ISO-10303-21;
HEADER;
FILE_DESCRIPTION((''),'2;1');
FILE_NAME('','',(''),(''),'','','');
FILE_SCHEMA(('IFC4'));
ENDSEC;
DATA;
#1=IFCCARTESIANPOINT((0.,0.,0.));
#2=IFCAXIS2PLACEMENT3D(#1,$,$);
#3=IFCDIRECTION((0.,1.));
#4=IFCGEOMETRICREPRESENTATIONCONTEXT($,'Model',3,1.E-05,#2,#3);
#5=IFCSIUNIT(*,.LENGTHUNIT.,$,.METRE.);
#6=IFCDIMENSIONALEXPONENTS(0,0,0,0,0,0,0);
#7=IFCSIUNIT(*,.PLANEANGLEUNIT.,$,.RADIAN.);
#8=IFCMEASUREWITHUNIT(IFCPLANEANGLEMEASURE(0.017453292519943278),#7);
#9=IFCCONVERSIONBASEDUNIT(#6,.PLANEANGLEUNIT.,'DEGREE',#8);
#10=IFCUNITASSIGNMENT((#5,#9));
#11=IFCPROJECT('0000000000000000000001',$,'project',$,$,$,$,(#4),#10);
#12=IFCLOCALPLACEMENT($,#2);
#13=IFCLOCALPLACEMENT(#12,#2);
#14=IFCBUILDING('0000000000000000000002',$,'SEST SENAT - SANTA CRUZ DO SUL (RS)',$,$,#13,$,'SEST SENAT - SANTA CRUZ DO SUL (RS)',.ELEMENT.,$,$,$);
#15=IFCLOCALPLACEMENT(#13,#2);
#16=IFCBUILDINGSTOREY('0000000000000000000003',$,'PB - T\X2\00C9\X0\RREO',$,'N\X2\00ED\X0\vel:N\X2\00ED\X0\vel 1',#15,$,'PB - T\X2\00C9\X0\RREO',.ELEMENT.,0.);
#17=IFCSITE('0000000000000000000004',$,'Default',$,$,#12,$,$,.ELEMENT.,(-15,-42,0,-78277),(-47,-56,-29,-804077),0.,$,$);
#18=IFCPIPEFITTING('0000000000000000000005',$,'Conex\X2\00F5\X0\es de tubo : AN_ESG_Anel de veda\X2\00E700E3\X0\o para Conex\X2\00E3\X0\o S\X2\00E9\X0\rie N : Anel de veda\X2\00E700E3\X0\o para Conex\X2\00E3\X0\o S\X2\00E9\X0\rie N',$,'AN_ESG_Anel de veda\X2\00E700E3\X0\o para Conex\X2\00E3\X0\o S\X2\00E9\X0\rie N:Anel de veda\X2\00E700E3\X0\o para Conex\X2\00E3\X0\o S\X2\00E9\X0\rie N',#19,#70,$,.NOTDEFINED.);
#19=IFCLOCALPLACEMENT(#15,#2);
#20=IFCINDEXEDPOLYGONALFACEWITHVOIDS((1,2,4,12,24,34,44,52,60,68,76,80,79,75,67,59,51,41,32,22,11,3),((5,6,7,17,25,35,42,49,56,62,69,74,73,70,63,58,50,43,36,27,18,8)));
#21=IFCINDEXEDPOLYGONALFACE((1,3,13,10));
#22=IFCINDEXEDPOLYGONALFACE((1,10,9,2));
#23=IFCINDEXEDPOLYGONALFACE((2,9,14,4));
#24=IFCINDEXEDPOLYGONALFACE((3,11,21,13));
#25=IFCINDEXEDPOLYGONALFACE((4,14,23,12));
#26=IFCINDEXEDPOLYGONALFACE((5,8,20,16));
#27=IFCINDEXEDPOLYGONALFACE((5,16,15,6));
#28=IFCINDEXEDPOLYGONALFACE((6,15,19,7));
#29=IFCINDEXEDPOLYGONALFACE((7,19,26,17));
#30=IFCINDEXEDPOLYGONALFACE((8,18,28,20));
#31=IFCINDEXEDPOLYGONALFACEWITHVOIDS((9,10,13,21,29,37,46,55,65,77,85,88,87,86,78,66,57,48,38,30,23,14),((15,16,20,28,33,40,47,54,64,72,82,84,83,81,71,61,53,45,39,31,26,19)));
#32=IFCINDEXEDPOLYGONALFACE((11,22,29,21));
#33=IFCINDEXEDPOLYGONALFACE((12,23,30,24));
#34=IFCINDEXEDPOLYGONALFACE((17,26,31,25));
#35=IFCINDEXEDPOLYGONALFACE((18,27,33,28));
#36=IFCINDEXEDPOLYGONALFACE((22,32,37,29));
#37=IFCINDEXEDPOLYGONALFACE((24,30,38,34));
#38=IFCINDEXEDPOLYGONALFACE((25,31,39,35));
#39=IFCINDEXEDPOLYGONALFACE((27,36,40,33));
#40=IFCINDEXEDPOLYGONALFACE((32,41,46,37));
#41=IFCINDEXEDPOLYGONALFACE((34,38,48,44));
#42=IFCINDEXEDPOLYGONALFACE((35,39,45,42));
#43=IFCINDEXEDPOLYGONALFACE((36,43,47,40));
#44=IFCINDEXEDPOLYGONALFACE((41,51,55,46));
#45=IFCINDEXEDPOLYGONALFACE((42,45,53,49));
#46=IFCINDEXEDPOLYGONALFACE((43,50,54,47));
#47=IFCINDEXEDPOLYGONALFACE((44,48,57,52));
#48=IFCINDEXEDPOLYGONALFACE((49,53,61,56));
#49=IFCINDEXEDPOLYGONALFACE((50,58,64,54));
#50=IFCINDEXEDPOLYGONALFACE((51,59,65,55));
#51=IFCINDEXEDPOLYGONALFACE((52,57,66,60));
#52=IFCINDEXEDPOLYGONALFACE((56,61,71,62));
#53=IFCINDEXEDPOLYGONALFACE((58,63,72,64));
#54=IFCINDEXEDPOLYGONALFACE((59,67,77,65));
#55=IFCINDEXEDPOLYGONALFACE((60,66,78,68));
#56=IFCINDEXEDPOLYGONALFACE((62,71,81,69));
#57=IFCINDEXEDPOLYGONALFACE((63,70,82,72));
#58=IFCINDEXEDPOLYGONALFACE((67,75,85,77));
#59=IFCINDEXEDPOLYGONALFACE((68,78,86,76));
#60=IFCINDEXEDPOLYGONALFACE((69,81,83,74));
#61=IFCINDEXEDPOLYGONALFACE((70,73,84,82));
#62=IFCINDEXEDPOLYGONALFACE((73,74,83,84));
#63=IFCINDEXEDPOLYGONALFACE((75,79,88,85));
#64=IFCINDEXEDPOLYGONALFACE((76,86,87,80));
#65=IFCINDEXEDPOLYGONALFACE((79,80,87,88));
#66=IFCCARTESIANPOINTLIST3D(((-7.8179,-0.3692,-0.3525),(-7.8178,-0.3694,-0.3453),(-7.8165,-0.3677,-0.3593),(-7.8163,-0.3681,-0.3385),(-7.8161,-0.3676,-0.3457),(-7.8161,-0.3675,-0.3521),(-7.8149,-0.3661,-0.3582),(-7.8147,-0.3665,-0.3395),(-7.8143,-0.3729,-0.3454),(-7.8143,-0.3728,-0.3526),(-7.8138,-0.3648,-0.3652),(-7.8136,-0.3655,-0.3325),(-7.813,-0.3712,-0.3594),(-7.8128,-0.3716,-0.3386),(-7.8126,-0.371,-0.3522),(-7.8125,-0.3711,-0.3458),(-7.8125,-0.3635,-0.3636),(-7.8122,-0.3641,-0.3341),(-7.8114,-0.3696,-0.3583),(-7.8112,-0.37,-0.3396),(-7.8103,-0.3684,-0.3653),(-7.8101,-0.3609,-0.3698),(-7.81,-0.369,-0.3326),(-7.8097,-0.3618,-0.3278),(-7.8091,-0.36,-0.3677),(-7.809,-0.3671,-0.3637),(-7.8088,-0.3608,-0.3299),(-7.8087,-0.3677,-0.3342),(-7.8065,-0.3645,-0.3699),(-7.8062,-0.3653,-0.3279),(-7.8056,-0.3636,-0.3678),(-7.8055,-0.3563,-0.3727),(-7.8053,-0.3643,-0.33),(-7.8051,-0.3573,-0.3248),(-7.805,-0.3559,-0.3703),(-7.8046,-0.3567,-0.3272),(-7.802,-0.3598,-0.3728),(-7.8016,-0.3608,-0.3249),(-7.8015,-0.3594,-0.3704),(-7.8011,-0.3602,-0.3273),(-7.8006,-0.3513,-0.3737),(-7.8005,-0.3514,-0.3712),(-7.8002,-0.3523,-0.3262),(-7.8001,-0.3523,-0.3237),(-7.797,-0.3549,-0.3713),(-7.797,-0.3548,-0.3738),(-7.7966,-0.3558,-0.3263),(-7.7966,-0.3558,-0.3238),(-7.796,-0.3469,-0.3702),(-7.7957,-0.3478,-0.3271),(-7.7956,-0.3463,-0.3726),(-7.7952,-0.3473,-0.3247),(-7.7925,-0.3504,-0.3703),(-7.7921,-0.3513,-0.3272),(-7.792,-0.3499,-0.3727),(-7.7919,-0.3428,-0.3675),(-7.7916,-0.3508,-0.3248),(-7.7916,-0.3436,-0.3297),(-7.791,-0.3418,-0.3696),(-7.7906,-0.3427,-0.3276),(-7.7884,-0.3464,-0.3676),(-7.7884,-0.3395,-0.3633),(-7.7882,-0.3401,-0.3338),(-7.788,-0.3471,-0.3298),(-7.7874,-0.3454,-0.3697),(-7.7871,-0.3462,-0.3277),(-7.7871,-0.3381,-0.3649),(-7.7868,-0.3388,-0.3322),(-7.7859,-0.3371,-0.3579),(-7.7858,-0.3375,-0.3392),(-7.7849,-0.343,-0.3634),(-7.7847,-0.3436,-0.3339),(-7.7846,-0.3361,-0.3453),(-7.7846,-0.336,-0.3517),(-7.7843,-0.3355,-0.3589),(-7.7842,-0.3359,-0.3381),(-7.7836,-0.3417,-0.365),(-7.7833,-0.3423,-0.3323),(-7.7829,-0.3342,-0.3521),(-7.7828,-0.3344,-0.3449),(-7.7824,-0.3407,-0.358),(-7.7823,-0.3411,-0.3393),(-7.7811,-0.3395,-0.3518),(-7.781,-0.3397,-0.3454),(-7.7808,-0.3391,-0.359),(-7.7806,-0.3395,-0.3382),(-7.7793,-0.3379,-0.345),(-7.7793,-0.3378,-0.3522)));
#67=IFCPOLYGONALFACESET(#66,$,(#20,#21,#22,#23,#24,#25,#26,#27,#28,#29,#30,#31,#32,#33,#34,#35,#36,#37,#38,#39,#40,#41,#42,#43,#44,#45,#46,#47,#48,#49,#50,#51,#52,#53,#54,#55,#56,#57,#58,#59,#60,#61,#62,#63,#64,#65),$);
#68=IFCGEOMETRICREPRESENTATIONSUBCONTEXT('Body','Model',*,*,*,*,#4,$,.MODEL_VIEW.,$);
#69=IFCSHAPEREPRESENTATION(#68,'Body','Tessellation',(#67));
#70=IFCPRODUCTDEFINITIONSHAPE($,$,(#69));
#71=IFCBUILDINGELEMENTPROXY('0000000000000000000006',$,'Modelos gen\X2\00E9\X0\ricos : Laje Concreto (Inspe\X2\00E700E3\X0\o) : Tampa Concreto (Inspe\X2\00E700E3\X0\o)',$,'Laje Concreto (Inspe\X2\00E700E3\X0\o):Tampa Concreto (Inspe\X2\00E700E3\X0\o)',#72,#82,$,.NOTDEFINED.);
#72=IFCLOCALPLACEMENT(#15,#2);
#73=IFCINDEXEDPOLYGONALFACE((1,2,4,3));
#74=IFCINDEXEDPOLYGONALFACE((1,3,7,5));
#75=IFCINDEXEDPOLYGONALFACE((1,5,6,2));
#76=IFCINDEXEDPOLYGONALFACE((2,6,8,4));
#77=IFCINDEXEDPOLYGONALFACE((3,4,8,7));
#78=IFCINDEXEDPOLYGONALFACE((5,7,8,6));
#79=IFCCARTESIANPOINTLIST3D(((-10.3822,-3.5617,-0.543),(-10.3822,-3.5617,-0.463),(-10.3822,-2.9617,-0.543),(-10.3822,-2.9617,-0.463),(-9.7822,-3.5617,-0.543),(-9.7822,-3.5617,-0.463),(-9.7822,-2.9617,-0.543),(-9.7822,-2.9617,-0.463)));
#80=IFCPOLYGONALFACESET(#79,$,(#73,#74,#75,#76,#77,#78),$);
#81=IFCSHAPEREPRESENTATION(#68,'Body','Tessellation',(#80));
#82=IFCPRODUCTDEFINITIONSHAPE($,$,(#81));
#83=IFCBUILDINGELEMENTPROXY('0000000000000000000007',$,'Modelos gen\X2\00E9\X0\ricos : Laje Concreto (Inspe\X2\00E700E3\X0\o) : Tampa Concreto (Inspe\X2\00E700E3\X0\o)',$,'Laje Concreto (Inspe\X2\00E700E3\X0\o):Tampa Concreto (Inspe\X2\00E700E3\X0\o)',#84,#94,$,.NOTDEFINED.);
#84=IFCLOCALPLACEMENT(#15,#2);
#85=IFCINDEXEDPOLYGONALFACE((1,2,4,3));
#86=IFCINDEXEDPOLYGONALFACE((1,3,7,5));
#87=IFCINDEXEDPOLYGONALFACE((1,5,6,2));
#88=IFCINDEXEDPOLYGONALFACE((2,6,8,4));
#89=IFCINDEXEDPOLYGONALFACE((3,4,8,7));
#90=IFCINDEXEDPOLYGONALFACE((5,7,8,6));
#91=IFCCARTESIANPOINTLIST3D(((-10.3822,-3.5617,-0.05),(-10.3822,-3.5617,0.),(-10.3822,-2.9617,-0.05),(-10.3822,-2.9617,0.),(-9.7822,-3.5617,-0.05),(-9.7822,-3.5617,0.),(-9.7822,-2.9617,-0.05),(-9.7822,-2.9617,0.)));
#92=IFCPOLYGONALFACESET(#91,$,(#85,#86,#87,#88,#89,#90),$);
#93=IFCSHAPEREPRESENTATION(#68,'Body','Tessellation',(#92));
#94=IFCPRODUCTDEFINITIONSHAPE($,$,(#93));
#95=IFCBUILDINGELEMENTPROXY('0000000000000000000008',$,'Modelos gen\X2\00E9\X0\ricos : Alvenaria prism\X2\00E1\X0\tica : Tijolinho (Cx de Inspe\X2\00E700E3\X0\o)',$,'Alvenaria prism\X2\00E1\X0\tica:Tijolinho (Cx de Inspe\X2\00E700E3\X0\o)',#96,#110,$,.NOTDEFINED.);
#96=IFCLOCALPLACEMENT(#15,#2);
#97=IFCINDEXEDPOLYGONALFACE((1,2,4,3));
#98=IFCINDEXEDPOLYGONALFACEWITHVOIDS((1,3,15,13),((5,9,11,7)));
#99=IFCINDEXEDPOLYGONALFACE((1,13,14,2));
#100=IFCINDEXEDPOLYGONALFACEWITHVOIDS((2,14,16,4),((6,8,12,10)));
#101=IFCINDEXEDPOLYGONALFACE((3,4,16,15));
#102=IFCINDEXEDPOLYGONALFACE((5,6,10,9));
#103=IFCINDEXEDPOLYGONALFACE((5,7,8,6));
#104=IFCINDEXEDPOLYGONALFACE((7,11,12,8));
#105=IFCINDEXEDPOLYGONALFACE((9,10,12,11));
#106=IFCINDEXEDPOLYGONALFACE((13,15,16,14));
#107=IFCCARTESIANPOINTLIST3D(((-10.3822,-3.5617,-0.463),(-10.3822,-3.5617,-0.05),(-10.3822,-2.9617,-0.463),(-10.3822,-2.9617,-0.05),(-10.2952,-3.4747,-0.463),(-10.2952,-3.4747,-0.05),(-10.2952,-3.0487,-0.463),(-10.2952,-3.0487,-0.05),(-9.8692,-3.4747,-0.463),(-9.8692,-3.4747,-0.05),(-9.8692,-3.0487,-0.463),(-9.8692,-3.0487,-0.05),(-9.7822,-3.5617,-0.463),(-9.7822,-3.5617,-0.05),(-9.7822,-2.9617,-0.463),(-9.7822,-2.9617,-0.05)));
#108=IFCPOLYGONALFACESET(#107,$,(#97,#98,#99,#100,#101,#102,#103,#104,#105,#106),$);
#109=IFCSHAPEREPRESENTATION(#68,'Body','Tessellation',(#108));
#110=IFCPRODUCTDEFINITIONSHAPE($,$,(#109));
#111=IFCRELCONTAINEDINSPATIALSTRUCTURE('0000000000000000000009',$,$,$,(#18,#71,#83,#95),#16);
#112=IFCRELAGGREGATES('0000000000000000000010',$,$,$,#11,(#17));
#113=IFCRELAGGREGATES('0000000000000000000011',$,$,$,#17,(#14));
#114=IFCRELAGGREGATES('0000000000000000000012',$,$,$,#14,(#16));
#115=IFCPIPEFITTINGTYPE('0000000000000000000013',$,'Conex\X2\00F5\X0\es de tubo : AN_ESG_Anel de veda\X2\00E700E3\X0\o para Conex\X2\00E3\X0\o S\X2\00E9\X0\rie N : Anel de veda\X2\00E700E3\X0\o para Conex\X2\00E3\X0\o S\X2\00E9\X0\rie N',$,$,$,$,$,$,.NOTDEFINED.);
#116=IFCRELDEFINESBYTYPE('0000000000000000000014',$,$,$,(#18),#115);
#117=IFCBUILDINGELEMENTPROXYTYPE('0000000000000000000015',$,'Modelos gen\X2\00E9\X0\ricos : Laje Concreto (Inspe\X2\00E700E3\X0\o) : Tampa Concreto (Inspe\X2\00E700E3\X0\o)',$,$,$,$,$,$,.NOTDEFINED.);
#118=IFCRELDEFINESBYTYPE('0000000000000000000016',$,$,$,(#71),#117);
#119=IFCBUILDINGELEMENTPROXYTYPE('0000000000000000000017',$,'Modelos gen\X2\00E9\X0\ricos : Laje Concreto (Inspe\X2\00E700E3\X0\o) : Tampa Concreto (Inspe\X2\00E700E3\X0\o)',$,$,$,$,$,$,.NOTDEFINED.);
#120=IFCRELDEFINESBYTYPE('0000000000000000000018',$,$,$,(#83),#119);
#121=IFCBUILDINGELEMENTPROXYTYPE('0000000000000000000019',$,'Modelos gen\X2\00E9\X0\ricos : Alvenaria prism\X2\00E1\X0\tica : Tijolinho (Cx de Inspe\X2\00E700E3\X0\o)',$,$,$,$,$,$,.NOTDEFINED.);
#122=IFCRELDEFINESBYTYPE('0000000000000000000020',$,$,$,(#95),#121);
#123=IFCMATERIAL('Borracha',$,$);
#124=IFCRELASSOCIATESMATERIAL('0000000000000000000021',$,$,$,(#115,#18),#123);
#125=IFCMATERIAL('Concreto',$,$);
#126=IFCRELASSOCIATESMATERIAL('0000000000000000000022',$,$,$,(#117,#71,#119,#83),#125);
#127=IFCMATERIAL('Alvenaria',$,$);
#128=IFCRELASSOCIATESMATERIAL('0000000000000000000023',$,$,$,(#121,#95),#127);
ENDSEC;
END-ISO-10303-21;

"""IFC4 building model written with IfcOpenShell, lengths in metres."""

from ifc_helpers import new_model, entity, si_unit, converted_unit, direction, frame, origin, place, context, subcontext, project, spatial, arc, indexed_curve, outline, extrude, source, transform, mapped, material, type_object, type_shapes, element, save


model = new_model("IFC4")

# Units and contexts
model_context = context("Model", 3, precision=1e-05, world=origin(), true_north=direction((0.0, 1.0)))
body_context = subcontext(model_context, "Body", "Model", "MODEL_VIEW")
ifc_project = project(units=[si_unit("LENGTHUNIT", "METRE"), converted_unit("PLANEANGLEUNIT", "DEGREE", entity("IfcPlaneAngleMeasure", 0.017453292519943278), si_unit("PLANEANGLEUNIT", "RADIAN"), dimensions=[0, 0, 0, 0, 0, 0, 0])], contexts=[model_context])

# Site, building, storey
site_placement = place(None, origin())
site = spatial("IfcSite", under=ifc_project, at=site_placement, Name="Default", CompositionType="ELEMENT", RefLatitude=(-15, -42, 0, -78277), RefLongitude=(-47, -56, -29, -804077), RefElevation=0.0)
building_placement = place(site_placement, origin())
building = spatial("IfcBuilding", under=site, at=building_placement, Name="SEST SENAT - SANTA CRUZ DO SUL (RS)", LongName="SEST SENAT - SANTA CRUZ DO SUL (RS)", CompositionType="ELEMENT")
storey_placement = place(building_placement, origin())
storey = spatial("IfcBuildingStorey", under=building, at=storey_placement, Name="PB - TÉRREO", ObjectType="Nível:Nível 1", LongName="PB - TÉRREO", CompositionType="ELEMENT", Elevation=0.0)

# Pipe fitting
ifc_material_1 = material(Name="Borracha")
pipe_fitting_type_1 = type_object("IfcPipeFittingType", Name="Conexões de tubo : AN_ESG_Anel de vedação para Conexão Série N : Anel de vedação para Conexão Série N", PredefinedType="NOTDEFINED", material=ifc_material_1)
shared_shape_1 = source(origin(), body_context, "Body", "SweptSolid", [
    extrude(outline(indexed_curve([(-0.025, 0.0), (0.0, -0.025), (0.025, 0.0), (0.0, 0.025)], segments=[arc(1, 2, 3), arc(3, 4, 1)], self_intersect=False), holes=[indexed_curve([(-0.0225, 0.0), (0.0, 0.0225), (0.0225, 0.0), (0.0, -0.0225)], segments=[arc(1, 2, 3), arc(3, 4, 1)], self_intersect=False)]), frame((0.0, 0.0, -0.005)), (0.0, 0.0, 1.0), 0.005),
])
type_shapes(pipe_fitting_type_1, [shared_shape_1])
for number, where, z_axis, x_axis, name in (
    (1, (-7.8003, -0.3518, -0.3487), (-0.706948, 0.706983, 0.019996), (0.008332, -0.019945, 0.999766), "Conexões de tubo : AN_ESG_Anel de vedação para Conexão Série N : Anel de vedação para Conexão Série N"),
):
    element("IfcPipeFitting", number, at=place(storey_placement, frame(where, z_axis=z_axis, x_axis=x_axis)), inside=storey, type_object=pipe_fitting_type_1, material=ifc_material_1, Name=name, ObjectType="AN_ESG_Anel de vedação para Conexão Série N:Anel de vedação para Conexão Série N", PredefinedType="NOTDEFINED", context=body_context, shape_type="MappedRepresentation", body=[
        mapped(shared_shape_1, transform((0.0, 0.0, 0.0), scale=1.0)),
    ])

# Building element proxies
ifc_material_2 = material(Name="Concreto")
building_element_proxy_type_1 = type_object("IfcBuildingElementProxyType", Name="Modelos genéricos : Laje Concreto (Inspeção) : Tampa Concreto (Inspeção)", PredefinedType="NOTDEFINED", material=ifc_material_2)
shared_shape_2 = source(origin(), body_context, "Body", "SweptSolid", [
    extrude(outline(indexed_curve([(-0.3, -0.3), (0.3, -0.3), (0.3, 0.3), (-0.3, 0.3), (-0.3, -0.3)], self_intersect=False)), frame((0.3, 0.0, -0.08), z_axis=(0.0, 0.0, 1.0), x_axis=(-1.0, 0.0, 0.0)), (0.0, 0.0, 1.0), 0.08),
])
type_shapes(building_element_proxy_type_1, [shared_shape_2])
proxy_1_placement = place(storey_placement, frame((-9.7822, -3.2617, -0.463), z_axis=(0.0, 0.0, 1.0), x_axis=(-1.0, 0.0, 0.0)))
element("IfcBuildingElementProxy", 2, at=proxy_1_placement, inside=storey, type_object=building_element_proxy_type_1, material=ifc_material_2, Name="Modelos genéricos : Laje Concreto (Inspeção) : Tampa Concreto (Inspeção)", ObjectType="Laje Concreto (Inspeção):Tampa Concreto (Inspeção)", PredefinedType="NOTDEFINED", context=body_context, shape_type="MappedRepresentation", body=[
    mapped(shared_shape_2, transform((0.0, 0.0, 0.0), scale=1.0)),
])
building_element_proxy_type_2 = type_object("IfcBuildingElementProxyType", Name="Modelos genéricos : Laje Concreto (Inspeção) : Tampa Concreto (Inspeção)", PredefinedType="NOTDEFINED", material=ifc_material_2)
shared_shape_3 = source(origin(), body_context, "Body", "SweptSolid", [
    extrude(outline(indexed_curve([(-0.3, -0.3), (0.3, -0.3), (0.3, 0.3), (-0.3, 0.3), (-0.3, -0.3)], self_intersect=False)), frame((0.3, 0.0, -0.05), z_axis=(0.0, 0.0, 1.0), x_axis=(-1.0, 0.0, 0.0)), (0.0, 0.0, 1.0), 0.05),
])
type_shapes(building_element_proxy_type_2, [shared_shape_3])
proxy_2_placement = place(storey_placement, frame((-9.7822, -3.2617, 0.0), z_axis=(0.0, 0.0, 1.0), x_axis=(-1.0, 0.0, 0.0)))
element("IfcBuildingElementProxy", 3, at=proxy_2_placement, inside=storey, type_object=building_element_proxy_type_2, material=ifc_material_2, Name="Modelos genéricos : Laje Concreto (Inspeção) : Tampa Concreto (Inspeção)", ObjectType="Laje Concreto (Inspeção):Tampa Concreto (Inspeção)", PredefinedType="NOTDEFINED", context=body_context, shape_type="MappedRepresentation", body=[
    mapped(shared_shape_3, transform((0.0, 0.0, 0.0), scale=1.0)),
])
ifc_material_3 = material(Name="Alvenaria")
building_element_proxy_type_3 = type_object("IfcBuildingElementProxyType", Name="Modelos genéricos : Alvenaria prismática : Tijolinho (Cx de Inspeção)", PredefinedType="NOTDEFINED", material=ifc_material_3)
shared_shape_4 = source(origin(), body_context, "Body", "SweptSolid", [
    extrude(outline(indexed_curve([(-0.3, -0.3), (0.3, -0.3), (0.3, 0.3), (-0.3, 0.3), (-0.3, -0.3)], self_intersect=False), holes=[indexed_curve([(0.213, 0.213), (0.213, -0.213), (-0.213, -0.213), (-0.213, 0.213), (0.213, 0.213)], self_intersect=False)]), frame((0.3, 0.0, -0.013), z_axis=(0.0, 0.0, 1.0), x_axis=(-1.0, 0.0, 0.0)), (0.0, 0.0, 1.0), 0.413),
])
type_shapes(building_element_proxy_type_3, [shared_shape_4])
proxy_3_placement = place(storey_placement, frame((-9.7822, -3.2617, -0.45), z_axis=(0.0, 0.0, 1.0), x_axis=(-1.0, 0.0, 0.0)))
element("IfcBuildingElementProxy", 4, at=proxy_3_placement, inside=storey, type_object=building_element_proxy_type_3, material=ifc_material_3, Name="Modelos genéricos : Alvenaria prismática : Tijolinho (Cx de Inspeção)", ObjectType="Alvenaria prismática:Tijolinho (Cx de Inspeção)", PredefinedType="NOTDEFINED", context=body_context, shape_type="MappedRepresentation", body=[
    mapped(shared_shape_4, transform((0.0, 0.0, 0.0), scale=1.0)),
])

save(model, "model.ifc")
